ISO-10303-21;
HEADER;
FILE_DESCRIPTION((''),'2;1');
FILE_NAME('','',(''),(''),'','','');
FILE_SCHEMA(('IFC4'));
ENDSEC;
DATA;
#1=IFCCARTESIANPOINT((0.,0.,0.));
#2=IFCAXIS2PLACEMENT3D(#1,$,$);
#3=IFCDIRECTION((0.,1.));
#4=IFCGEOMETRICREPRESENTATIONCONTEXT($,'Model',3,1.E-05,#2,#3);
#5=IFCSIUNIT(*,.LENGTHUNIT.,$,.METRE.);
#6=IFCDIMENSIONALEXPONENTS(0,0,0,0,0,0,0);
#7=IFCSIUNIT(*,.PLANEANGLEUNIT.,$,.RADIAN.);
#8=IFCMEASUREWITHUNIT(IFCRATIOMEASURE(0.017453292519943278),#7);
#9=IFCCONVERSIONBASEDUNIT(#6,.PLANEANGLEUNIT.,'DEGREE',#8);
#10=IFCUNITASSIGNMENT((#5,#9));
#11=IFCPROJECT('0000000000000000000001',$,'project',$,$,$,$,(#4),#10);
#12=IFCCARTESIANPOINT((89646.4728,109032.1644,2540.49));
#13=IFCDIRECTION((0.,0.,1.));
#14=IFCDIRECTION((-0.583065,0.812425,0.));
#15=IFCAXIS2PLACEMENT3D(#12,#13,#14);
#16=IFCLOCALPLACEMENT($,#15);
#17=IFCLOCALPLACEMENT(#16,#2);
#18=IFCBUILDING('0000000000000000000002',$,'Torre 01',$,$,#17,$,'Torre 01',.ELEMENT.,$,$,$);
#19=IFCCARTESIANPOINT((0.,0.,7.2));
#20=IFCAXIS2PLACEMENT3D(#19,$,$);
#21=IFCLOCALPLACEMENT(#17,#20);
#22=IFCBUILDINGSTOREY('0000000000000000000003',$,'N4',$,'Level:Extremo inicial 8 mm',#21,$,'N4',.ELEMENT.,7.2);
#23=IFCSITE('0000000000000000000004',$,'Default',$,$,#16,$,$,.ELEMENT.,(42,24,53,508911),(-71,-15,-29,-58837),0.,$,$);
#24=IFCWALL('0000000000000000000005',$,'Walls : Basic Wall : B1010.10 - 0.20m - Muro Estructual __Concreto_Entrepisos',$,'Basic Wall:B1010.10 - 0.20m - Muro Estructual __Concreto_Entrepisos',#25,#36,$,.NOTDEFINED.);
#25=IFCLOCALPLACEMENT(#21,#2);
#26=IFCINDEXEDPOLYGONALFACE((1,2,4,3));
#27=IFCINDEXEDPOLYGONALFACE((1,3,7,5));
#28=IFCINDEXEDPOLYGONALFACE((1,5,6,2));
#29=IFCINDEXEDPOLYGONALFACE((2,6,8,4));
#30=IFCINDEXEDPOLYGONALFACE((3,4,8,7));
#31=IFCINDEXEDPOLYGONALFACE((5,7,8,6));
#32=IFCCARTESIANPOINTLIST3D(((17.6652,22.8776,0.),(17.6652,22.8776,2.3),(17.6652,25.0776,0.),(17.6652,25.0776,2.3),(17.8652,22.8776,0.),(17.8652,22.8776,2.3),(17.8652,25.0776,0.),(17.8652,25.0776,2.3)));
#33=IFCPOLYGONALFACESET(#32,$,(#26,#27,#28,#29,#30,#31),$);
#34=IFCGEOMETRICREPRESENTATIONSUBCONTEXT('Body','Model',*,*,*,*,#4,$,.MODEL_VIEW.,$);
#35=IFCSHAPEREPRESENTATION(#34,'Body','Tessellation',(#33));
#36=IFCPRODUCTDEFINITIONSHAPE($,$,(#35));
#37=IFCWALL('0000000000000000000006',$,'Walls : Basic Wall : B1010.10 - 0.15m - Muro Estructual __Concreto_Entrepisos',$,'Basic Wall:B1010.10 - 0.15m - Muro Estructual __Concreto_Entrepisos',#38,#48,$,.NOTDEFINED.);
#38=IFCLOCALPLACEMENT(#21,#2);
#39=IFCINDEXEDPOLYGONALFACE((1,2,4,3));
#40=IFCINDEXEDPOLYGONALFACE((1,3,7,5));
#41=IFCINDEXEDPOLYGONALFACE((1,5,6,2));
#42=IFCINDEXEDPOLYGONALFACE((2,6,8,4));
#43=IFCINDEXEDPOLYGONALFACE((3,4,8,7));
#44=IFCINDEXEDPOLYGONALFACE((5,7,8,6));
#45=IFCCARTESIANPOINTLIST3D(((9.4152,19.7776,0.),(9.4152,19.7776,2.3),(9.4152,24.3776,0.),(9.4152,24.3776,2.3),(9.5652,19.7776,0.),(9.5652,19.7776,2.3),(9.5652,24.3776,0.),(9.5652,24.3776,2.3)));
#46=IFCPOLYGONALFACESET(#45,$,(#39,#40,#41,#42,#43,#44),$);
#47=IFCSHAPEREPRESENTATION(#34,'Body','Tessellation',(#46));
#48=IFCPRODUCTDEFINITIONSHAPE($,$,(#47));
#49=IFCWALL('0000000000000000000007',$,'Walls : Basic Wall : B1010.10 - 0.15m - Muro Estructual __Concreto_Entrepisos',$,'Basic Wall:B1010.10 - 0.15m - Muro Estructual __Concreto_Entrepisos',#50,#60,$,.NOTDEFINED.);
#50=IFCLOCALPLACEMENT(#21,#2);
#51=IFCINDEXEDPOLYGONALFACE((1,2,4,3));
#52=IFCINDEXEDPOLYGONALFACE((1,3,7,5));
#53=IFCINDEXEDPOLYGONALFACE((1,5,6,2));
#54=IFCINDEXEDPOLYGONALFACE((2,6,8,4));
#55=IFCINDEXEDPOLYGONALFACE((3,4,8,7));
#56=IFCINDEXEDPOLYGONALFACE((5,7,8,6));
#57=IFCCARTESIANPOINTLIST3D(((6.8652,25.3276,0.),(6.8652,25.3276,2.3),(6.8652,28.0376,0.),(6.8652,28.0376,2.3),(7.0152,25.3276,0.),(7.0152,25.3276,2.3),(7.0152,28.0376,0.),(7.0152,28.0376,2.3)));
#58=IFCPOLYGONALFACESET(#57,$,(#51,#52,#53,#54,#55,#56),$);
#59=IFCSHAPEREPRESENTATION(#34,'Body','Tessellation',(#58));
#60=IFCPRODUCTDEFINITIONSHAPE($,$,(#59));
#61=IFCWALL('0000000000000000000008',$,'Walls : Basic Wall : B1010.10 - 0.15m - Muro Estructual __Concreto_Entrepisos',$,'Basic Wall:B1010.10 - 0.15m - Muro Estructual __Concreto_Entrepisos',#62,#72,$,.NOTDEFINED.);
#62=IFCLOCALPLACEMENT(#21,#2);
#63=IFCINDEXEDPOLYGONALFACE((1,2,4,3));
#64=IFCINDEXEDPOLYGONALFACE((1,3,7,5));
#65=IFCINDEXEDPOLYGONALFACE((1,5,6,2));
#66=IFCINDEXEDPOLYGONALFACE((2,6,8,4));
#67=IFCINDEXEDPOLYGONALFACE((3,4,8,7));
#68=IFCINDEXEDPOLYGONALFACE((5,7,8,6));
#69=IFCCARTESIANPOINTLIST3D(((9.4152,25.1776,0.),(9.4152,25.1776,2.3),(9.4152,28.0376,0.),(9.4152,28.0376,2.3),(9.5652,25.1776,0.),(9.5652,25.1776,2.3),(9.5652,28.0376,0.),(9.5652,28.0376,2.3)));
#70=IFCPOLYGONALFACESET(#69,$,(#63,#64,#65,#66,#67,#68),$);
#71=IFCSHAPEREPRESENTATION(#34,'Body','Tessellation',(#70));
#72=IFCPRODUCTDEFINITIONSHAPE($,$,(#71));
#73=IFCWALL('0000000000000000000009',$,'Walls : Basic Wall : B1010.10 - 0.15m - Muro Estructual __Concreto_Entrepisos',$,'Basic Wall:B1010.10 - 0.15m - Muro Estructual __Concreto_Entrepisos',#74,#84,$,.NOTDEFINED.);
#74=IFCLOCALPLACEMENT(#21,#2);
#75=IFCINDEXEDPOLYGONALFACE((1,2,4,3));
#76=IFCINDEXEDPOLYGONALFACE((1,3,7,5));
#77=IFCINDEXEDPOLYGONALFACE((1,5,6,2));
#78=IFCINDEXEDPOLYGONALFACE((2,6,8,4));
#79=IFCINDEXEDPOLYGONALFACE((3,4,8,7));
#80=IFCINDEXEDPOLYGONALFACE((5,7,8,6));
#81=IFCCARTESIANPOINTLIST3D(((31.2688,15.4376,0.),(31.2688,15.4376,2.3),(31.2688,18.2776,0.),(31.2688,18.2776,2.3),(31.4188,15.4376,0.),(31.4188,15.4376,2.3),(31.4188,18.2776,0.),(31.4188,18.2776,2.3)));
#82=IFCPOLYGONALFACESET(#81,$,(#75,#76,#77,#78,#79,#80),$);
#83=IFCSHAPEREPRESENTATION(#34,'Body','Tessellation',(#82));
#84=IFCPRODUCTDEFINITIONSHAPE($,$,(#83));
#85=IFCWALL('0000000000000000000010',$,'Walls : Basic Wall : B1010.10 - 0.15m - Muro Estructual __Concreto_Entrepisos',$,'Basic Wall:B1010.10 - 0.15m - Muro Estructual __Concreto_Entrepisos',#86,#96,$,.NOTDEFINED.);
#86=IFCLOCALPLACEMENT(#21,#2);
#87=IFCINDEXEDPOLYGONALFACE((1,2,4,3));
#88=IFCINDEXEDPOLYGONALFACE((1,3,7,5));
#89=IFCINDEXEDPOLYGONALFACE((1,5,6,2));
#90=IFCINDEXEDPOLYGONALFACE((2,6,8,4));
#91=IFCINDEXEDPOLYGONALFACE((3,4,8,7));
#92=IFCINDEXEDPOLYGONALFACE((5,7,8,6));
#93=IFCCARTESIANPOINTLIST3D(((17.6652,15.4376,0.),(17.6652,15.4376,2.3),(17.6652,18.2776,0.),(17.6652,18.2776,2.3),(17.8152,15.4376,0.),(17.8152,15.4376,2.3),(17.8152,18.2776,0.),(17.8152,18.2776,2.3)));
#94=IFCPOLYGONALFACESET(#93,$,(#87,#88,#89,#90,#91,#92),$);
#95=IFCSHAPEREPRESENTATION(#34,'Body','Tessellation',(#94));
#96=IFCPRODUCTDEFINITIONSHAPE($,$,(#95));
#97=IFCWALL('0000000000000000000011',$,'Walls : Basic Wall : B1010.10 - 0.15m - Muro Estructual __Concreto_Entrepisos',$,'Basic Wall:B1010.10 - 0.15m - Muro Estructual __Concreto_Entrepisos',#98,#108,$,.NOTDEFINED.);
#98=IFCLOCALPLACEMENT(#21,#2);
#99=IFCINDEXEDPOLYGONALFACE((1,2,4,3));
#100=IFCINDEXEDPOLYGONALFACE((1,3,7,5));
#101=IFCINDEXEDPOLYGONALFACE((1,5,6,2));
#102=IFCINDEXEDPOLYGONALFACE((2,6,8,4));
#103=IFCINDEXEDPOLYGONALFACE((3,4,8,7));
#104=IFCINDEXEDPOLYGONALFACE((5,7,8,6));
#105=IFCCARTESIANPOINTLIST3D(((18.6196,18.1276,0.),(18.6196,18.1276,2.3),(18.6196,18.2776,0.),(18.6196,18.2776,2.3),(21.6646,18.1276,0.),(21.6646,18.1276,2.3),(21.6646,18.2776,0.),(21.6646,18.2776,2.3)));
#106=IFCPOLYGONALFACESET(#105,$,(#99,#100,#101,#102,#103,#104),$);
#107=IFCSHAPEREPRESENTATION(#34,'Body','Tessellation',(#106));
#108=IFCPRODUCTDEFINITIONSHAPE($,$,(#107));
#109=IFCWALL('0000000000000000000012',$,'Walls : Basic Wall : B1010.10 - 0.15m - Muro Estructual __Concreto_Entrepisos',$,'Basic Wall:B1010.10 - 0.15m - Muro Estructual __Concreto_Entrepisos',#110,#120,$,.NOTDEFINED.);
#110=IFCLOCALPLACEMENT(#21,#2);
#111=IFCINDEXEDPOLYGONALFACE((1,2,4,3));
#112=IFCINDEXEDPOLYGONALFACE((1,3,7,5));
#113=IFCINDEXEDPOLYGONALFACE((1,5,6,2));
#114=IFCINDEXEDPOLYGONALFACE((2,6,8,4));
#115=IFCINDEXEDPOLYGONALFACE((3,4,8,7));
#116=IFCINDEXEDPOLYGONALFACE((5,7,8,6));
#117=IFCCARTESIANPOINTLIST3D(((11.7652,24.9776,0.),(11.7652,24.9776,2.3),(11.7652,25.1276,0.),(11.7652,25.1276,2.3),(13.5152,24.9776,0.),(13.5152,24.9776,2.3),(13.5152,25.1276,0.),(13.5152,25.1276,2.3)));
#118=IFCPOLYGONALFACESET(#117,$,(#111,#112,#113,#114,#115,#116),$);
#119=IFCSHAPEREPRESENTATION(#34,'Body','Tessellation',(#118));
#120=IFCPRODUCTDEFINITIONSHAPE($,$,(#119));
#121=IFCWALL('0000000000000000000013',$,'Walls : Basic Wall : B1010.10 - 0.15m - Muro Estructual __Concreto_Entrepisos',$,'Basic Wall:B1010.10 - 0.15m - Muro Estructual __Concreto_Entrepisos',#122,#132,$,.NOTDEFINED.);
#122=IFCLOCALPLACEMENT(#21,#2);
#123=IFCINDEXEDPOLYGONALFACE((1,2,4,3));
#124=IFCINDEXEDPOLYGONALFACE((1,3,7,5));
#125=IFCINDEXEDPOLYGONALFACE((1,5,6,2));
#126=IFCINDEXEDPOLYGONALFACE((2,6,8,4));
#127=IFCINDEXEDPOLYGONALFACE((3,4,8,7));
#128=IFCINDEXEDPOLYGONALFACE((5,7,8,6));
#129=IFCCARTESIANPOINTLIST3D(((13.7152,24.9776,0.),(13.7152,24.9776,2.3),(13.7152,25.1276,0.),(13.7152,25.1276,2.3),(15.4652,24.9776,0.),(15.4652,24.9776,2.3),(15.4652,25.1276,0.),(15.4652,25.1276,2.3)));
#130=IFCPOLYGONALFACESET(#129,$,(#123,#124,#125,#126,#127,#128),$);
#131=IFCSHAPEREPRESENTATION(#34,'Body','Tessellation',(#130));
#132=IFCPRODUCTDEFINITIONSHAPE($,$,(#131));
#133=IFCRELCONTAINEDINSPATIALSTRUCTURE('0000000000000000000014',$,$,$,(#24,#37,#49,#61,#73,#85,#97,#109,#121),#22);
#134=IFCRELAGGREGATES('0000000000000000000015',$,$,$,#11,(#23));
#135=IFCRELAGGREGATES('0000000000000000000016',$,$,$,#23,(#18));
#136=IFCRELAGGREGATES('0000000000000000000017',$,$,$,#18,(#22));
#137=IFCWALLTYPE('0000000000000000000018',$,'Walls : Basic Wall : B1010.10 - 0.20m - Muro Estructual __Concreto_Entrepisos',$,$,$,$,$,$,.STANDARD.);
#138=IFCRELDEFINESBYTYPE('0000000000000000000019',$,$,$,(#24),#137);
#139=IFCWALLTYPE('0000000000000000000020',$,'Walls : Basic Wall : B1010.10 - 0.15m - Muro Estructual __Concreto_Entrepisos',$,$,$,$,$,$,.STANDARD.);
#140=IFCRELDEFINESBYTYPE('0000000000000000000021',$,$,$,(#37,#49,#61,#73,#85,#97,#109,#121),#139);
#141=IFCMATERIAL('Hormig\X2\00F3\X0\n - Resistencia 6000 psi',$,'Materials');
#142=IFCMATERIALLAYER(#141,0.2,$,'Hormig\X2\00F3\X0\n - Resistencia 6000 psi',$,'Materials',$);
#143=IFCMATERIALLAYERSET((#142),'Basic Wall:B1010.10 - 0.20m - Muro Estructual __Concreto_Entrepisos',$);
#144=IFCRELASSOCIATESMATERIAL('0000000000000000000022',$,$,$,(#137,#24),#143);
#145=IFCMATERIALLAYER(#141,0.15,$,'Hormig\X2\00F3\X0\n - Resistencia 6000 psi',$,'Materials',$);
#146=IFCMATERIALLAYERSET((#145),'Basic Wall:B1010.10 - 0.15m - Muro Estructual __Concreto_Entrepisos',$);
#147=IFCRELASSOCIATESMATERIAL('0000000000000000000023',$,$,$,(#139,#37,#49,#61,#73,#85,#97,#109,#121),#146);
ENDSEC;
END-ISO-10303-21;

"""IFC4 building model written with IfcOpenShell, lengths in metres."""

from ifc_helpers import new_model, entity, si_unit, converted_unit, direction, frame, frame_2d, origin, place, context, subcontext, project, spatial, rectangle, extrude, material, layer, layer_set, layer_usage, type_object, element, save


model = new_model("IFC4")

# Units and contexts
model_context = context("Model", 3, precision=1e-05, world=origin(), true_north=direction((0.0, 1.0)))
body_context = subcontext(model_context, "Body", "Model", "MODEL_VIEW")
ifc_project = project(units=[si_unit("LENGTHUNIT", "METRE"), converted_unit("PLANEANGLEUNIT", "DEGREE", entity("IfcRatioMeasure", 0.017453292519943278), si_unit("PLANEANGLEUNIT", "RADIAN"), dimensions=[0, 0, 0, 0, 0, 0, 0])], contexts=[model_context])

# Site, building, storey
site_placement = place(None, frame((89646.4728, 109032.1644, 2540.49), z_axis=(0.0, 0.0, 1.0), x_axis=(-0.583065, 0.812425, 0.0)))
site = spatial("IfcSite", under=ifc_project, at=site_placement, Name="Default", CompositionType="ELEMENT", RefLatitude=(42, 24, 53, 508911), RefLongitude=(-71, -15, -29, -58837), RefElevation=0.0)
building_placement = place(site_placement, origin())
building = spatial("IfcBuilding", under=site, at=building_placement, Name="Torre 01", LongName="Torre 01", CompositionType="ELEMENT")
storey_placement = place(building_placement, frame((0.0, 0.0, 7.2)))
storey = spatial("IfcBuildingStorey", under=building, at=storey_placement, Name="N4", ObjectType="Level:Extremo inicial 8 mm", LongName="N4", CompositionType="ELEMENT", Elevation=7.2)

# Walls
ifc_material = material(Name="Hormigón - Resistencia 6000 psi", Category="Materials")
ifc_layer_1 = layer(ifc_material, 0.2, Name="Hormigón - Resistencia 6000 psi", Category="Materials")
ifc_layer_set_1 = layer_set([ifc_layer_1], Name="Basic Wall:B1010.10 - 0.20m - Muro Estructual __Concreto_Entrepisos")
wall_type_1 = type_object("IfcWallType", Name="Walls : Basic Wall : B1010.10 - 0.20m - Muro Estructual __Concreto_Entrepisos", PredefinedType="STANDARD", material=ifc_layer_set_1)
ifc_layer_usage_1 = layer_usage(ifc_layer_set_1, "AXIS2", "NEGATIVE", 0.1)
wall_1_placement = place(storey_placement, frame((17.7652, 22.8776, 0.0), z_axis=(0.0, 0.0, 1.0), x_axis=(0.0, 1.0, 0.0)))
element("IfcWall", 1, at=wall_1_placement, inside=storey, type_object=wall_type_1, material=ifc_layer_usage_1, Name="Walls : Basic Wall : B1010.10 - 0.20m - Muro Estructual __Concreto_Entrepisos", ObjectType="Basic Wall:B1010.10 - 0.20m - Muro Estructual __Concreto_Entrepisos", PredefinedType="NOTDEFINED", context=body_context, shape_type="SweptSolid", body=[
    extrude(rectangle(XDim=2.2, YDim=0.2, at=frame_2d((1.1, 0.0), x_axis=(-1.0, 0.0))), origin(), (0.0, 0.0, 1.0), 2.3),
])
ifc_layer_2 = layer(ifc_material, 0.15, Name="Hormigón - Resistencia 6000 psi", Category="Materials")
ifc_layer_set_2 = layer_set([ifc_layer_2], Name="Basic Wall:B1010.10 - 0.15m - Muro Estructual __Concreto_Entrepisos")
ifc_layer_usage_2 = layer_usage(ifc_layer_set_2, "AXIS2", "NEGATIVE", 0.075)
wall_type_2 = type_object("IfcWallType", Name="Walls : Basic Wall : B1010.10 - 0.15m - Muro Estructual __Concreto_Entrepisos", PredefinedType="STANDARD", material=ifc_layer_set_2)
wall_2_placement = place(storey_placement, frame((9.4902, 24.3776, 0.0), z_axis=(0.0, 0.0, 1.0), x_axis=(0.0, -1.0, 0.0)))
element("IfcWall", 2, at=wall_2_placement, inside=storey, type_object=wall_type_2, material=ifc_layer_usage_2, Name="Walls : Basic Wall : B1010.10 - 0.15m - Muro Estructual __Concreto_Entrepisos", ObjectType="Basic Wall:B1010.10 - 0.15m - Muro Estructual __Concreto_Entrepisos", PredefinedType="NOTDEFINED", context=body_context, shape_type="SweptSolid", body=[
    extrude(rectangle(XDim=4.6, YDim=0.15, at=frame_2d((2.3, 0.0), x_axis=(-1.0, 0.0))), origin(), (0.0, 0.0, 1.0), 2.3),
])
ifc_layer_usage_3 = layer_usage(ifc_layer_set_2, "AXIS2", "NEGATIVE", 0.075)
wall_3_placement = place(storey_placement, frame((6.9402, 25.3276, 0.0), z_axis=(0.0, 0.0, 1.0), x_axis=(0.0, 1.0, 0.0)))
element("IfcWall", 3, at=wall_3_placement, inside=storey, type_object=wall_type_2, material=ifc_layer_usage_3, Name="Walls : Basic Wall : B1010.10 - 0.15m - Muro Estructual __Concreto_Entrepisos", ObjectType="Basic Wall:B1010.10 - 0.15m - Muro Estructual __Concreto_Entrepisos", PredefinedType="NOTDEFINED", context=body_context, shape_type="SweptSolid", body=[
    extrude(rectangle(XDim=2.71, YDim=0.15, at=frame_2d((1.355, 0.0), x_axis=(-1.0, 0.0))), origin(), (0.0, 0.0, 1.0), 2.3),
])
ifc_layer_usage_4 = layer_usage(ifc_layer_set_2, "AXIS2", "NEGATIVE", 0.075)
wall_4_placement = place(storey_placement, frame((9.4902, 28.0376, 0.0), z_axis=(0.0, 0.0, 1.0), x_axis=(0.0, -1.0, 0.0)))
element("IfcWall", 4, at=wall_4_placement, inside=storey, type_object=wall_type_2, material=ifc_layer_usage_4, Name="Walls : Basic Wall : B1010.10 - 0.15m - Muro Estructual __Concreto_Entrepisos", ObjectType="Basic Wall:B1010.10 - 0.15m - Muro Estructual __Concreto_Entrepisos", PredefinedType="NOTDEFINED", context=body_context, shape_type="SweptSolid", body=[
    extrude(rectangle(XDim=2.86, YDim=0.15, at=frame_2d((1.43, 0.0), x_axis=(-1.0, 0.0))), origin(), (0.0, 0.0, 1.0), 2.3),
])
ifc_layer_usage_5 = layer_usage(ifc_layer_set_2, "AXIS2", "NEGATIVE", 0.075)
wall_5_placement = place(storey_placement, frame((31.3438, 15.4376, 0.0), z_axis=(0.0, 0.0, 1.0), x_axis=(0.0, 1.0, 0.0)))
element("IfcWall", 5, at=wall_5_placement, inside=storey, type_object=wall_type_2, material=ifc_layer_usage_5, Name="Walls : Basic Wall : B1010.10 - 0.15m - Muro Estructual __Concreto_Entrepisos", ObjectType="Basic Wall:B1010.10 - 0.15m - Muro Estructual __Concreto_Entrepisos", PredefinedType="NOTDEFINED", context=body_context, shape_type="SweptSolid", body=[
    extrude(rectangle(XDim=2.84, YDim=0.15, at=frame_2d((1.42, 0.0), x_axis=(-1.0, 0.0))), origin(), (0.0, 0.0, 1.0), 2.3),
])
ifc_layer_usage_6 = layer_usage(ifc_layer_set_2, "AXIS2", "NEGATIVE", 0.075)
wall_6_placement = place(storey_placement, frame((17.7402, 18.2776, 0.0), z_axis=(0.0, 0.0, 1.0), x_axis=(0.0, -1.0, 0.0)))
element("IfcWall", 6, at=wall_6_placement, inside=storey, type_object=wall_type_2, material=ifc_layer_usage_6, Name="Walls : Basic Wall : B1010.10 - 0.15m - Muro Estructual __Concreto_Entrepisos", ObjectType="Basic Wall:B1010.10 - 0.15m - Muro Estructual __Concreto_Entrepisos", PredefinedType="NOTDEFINED", context=body_context, shape_type="SweptSolid", body=[
    extrude(rectangle(XDim=2.84, YDim=0.15, at=frame_2d((1.42, 0.0), x_axis=(-1.0, 0.0))), origin(), (0.0, 0.0, 1.0), 2.3),
])
ifc_layer_usage_7 = layer_usage(ifc_layer_set_2, "AXIS2", "NEGATIVE", 0.075)
wall_7_placement = place(storey_placement, frame((18.6196, 18.2026, 0.0)))
element("IfcWall", 7, at=wall_7_placement, inside=storey, type_object=wall_type_2, material=ifc_layer_usage_7, Name="Walls : Basic Wall : B1010.10 - 0.15m - Muro Estructual __Concreto_Entrepisos", ObjectType="Basic Wall:B1010.10 - 0.15m - Muro Estructual __Concreto_Entrepisos", PredefinedType="NOTDEFINED", context=body_context, shape_type="SweptSolid", body=[
    extrude(rectangle(XDim=3.045, YDim=0.15, at=frame_2d((1.5225, 0.0), x_axis=(-1.0, 0.0))), origin(), (0.0, 0.0, 1.0), 2.3),
])
ifc_layer_usage_8 = layer_usage(ifc_layer_set_2, "AXIS2", "POSITIVE", -0.075)
wall_8_placement = place(storey_placement, frame((11.7652, 25.0526, 0.0)))
element("IfcWall", 8, at=wall_8_placement, inside=storey, type_object=wall_type_2, material=ifc_layer_usage_8, Name="Walls : Basic Wall : B1010.10 - 0.15m - Muro Estructual __Concreto_Entrepisos", ObjectType="Basic Wall:B1010.10 - 0.15m - Muro Estructual __Concreto_Entrepisos", PredefinedType="NOTDEFINED", context=body_context, shape_type="SweptSolid", body=[
    extrude(rectangle(XDim=1.75, YDim=0.15, at=frame_2d((0.875, 0.0), x_axis=(-1.0, 0.0))), origin(), (0.0, 0.0, 1.0), 2.3),
])
ifc_layer_usage_9 = layer_usage(ifc_layer_set_2, "AXIS2", "POSITIVE", -0.075)
wall_9_placement = place(storey_placement, frame((13.7152, 25.0526, 0.0)))
element("IfcWall", 9, at=wall_9_placement, inside=storey, type_object=wall_type_2, material=ifc_layer_usage_9, Name="Walls : Basic Wall : B1010.10 - 0.15m - Muro Estructual __Concreto_Entrepisos", ObjectType="Basic Wall:B1010.10 - 0.15m - Muro Estructual __Concreto_Entrepisos", PredefinedType="NOTDEFINED", context=body_context, shape_type="SweptSolid", body=[
    extrude(rectangle(XDim=1.75, YDim=0.15, at=frame_2d((0.875, 0.0), x_axis=(-1.0, 0.0))), origin(), (0.0, 0.0, 1.0), 2.3),
])

save(model, "model.ifc")
